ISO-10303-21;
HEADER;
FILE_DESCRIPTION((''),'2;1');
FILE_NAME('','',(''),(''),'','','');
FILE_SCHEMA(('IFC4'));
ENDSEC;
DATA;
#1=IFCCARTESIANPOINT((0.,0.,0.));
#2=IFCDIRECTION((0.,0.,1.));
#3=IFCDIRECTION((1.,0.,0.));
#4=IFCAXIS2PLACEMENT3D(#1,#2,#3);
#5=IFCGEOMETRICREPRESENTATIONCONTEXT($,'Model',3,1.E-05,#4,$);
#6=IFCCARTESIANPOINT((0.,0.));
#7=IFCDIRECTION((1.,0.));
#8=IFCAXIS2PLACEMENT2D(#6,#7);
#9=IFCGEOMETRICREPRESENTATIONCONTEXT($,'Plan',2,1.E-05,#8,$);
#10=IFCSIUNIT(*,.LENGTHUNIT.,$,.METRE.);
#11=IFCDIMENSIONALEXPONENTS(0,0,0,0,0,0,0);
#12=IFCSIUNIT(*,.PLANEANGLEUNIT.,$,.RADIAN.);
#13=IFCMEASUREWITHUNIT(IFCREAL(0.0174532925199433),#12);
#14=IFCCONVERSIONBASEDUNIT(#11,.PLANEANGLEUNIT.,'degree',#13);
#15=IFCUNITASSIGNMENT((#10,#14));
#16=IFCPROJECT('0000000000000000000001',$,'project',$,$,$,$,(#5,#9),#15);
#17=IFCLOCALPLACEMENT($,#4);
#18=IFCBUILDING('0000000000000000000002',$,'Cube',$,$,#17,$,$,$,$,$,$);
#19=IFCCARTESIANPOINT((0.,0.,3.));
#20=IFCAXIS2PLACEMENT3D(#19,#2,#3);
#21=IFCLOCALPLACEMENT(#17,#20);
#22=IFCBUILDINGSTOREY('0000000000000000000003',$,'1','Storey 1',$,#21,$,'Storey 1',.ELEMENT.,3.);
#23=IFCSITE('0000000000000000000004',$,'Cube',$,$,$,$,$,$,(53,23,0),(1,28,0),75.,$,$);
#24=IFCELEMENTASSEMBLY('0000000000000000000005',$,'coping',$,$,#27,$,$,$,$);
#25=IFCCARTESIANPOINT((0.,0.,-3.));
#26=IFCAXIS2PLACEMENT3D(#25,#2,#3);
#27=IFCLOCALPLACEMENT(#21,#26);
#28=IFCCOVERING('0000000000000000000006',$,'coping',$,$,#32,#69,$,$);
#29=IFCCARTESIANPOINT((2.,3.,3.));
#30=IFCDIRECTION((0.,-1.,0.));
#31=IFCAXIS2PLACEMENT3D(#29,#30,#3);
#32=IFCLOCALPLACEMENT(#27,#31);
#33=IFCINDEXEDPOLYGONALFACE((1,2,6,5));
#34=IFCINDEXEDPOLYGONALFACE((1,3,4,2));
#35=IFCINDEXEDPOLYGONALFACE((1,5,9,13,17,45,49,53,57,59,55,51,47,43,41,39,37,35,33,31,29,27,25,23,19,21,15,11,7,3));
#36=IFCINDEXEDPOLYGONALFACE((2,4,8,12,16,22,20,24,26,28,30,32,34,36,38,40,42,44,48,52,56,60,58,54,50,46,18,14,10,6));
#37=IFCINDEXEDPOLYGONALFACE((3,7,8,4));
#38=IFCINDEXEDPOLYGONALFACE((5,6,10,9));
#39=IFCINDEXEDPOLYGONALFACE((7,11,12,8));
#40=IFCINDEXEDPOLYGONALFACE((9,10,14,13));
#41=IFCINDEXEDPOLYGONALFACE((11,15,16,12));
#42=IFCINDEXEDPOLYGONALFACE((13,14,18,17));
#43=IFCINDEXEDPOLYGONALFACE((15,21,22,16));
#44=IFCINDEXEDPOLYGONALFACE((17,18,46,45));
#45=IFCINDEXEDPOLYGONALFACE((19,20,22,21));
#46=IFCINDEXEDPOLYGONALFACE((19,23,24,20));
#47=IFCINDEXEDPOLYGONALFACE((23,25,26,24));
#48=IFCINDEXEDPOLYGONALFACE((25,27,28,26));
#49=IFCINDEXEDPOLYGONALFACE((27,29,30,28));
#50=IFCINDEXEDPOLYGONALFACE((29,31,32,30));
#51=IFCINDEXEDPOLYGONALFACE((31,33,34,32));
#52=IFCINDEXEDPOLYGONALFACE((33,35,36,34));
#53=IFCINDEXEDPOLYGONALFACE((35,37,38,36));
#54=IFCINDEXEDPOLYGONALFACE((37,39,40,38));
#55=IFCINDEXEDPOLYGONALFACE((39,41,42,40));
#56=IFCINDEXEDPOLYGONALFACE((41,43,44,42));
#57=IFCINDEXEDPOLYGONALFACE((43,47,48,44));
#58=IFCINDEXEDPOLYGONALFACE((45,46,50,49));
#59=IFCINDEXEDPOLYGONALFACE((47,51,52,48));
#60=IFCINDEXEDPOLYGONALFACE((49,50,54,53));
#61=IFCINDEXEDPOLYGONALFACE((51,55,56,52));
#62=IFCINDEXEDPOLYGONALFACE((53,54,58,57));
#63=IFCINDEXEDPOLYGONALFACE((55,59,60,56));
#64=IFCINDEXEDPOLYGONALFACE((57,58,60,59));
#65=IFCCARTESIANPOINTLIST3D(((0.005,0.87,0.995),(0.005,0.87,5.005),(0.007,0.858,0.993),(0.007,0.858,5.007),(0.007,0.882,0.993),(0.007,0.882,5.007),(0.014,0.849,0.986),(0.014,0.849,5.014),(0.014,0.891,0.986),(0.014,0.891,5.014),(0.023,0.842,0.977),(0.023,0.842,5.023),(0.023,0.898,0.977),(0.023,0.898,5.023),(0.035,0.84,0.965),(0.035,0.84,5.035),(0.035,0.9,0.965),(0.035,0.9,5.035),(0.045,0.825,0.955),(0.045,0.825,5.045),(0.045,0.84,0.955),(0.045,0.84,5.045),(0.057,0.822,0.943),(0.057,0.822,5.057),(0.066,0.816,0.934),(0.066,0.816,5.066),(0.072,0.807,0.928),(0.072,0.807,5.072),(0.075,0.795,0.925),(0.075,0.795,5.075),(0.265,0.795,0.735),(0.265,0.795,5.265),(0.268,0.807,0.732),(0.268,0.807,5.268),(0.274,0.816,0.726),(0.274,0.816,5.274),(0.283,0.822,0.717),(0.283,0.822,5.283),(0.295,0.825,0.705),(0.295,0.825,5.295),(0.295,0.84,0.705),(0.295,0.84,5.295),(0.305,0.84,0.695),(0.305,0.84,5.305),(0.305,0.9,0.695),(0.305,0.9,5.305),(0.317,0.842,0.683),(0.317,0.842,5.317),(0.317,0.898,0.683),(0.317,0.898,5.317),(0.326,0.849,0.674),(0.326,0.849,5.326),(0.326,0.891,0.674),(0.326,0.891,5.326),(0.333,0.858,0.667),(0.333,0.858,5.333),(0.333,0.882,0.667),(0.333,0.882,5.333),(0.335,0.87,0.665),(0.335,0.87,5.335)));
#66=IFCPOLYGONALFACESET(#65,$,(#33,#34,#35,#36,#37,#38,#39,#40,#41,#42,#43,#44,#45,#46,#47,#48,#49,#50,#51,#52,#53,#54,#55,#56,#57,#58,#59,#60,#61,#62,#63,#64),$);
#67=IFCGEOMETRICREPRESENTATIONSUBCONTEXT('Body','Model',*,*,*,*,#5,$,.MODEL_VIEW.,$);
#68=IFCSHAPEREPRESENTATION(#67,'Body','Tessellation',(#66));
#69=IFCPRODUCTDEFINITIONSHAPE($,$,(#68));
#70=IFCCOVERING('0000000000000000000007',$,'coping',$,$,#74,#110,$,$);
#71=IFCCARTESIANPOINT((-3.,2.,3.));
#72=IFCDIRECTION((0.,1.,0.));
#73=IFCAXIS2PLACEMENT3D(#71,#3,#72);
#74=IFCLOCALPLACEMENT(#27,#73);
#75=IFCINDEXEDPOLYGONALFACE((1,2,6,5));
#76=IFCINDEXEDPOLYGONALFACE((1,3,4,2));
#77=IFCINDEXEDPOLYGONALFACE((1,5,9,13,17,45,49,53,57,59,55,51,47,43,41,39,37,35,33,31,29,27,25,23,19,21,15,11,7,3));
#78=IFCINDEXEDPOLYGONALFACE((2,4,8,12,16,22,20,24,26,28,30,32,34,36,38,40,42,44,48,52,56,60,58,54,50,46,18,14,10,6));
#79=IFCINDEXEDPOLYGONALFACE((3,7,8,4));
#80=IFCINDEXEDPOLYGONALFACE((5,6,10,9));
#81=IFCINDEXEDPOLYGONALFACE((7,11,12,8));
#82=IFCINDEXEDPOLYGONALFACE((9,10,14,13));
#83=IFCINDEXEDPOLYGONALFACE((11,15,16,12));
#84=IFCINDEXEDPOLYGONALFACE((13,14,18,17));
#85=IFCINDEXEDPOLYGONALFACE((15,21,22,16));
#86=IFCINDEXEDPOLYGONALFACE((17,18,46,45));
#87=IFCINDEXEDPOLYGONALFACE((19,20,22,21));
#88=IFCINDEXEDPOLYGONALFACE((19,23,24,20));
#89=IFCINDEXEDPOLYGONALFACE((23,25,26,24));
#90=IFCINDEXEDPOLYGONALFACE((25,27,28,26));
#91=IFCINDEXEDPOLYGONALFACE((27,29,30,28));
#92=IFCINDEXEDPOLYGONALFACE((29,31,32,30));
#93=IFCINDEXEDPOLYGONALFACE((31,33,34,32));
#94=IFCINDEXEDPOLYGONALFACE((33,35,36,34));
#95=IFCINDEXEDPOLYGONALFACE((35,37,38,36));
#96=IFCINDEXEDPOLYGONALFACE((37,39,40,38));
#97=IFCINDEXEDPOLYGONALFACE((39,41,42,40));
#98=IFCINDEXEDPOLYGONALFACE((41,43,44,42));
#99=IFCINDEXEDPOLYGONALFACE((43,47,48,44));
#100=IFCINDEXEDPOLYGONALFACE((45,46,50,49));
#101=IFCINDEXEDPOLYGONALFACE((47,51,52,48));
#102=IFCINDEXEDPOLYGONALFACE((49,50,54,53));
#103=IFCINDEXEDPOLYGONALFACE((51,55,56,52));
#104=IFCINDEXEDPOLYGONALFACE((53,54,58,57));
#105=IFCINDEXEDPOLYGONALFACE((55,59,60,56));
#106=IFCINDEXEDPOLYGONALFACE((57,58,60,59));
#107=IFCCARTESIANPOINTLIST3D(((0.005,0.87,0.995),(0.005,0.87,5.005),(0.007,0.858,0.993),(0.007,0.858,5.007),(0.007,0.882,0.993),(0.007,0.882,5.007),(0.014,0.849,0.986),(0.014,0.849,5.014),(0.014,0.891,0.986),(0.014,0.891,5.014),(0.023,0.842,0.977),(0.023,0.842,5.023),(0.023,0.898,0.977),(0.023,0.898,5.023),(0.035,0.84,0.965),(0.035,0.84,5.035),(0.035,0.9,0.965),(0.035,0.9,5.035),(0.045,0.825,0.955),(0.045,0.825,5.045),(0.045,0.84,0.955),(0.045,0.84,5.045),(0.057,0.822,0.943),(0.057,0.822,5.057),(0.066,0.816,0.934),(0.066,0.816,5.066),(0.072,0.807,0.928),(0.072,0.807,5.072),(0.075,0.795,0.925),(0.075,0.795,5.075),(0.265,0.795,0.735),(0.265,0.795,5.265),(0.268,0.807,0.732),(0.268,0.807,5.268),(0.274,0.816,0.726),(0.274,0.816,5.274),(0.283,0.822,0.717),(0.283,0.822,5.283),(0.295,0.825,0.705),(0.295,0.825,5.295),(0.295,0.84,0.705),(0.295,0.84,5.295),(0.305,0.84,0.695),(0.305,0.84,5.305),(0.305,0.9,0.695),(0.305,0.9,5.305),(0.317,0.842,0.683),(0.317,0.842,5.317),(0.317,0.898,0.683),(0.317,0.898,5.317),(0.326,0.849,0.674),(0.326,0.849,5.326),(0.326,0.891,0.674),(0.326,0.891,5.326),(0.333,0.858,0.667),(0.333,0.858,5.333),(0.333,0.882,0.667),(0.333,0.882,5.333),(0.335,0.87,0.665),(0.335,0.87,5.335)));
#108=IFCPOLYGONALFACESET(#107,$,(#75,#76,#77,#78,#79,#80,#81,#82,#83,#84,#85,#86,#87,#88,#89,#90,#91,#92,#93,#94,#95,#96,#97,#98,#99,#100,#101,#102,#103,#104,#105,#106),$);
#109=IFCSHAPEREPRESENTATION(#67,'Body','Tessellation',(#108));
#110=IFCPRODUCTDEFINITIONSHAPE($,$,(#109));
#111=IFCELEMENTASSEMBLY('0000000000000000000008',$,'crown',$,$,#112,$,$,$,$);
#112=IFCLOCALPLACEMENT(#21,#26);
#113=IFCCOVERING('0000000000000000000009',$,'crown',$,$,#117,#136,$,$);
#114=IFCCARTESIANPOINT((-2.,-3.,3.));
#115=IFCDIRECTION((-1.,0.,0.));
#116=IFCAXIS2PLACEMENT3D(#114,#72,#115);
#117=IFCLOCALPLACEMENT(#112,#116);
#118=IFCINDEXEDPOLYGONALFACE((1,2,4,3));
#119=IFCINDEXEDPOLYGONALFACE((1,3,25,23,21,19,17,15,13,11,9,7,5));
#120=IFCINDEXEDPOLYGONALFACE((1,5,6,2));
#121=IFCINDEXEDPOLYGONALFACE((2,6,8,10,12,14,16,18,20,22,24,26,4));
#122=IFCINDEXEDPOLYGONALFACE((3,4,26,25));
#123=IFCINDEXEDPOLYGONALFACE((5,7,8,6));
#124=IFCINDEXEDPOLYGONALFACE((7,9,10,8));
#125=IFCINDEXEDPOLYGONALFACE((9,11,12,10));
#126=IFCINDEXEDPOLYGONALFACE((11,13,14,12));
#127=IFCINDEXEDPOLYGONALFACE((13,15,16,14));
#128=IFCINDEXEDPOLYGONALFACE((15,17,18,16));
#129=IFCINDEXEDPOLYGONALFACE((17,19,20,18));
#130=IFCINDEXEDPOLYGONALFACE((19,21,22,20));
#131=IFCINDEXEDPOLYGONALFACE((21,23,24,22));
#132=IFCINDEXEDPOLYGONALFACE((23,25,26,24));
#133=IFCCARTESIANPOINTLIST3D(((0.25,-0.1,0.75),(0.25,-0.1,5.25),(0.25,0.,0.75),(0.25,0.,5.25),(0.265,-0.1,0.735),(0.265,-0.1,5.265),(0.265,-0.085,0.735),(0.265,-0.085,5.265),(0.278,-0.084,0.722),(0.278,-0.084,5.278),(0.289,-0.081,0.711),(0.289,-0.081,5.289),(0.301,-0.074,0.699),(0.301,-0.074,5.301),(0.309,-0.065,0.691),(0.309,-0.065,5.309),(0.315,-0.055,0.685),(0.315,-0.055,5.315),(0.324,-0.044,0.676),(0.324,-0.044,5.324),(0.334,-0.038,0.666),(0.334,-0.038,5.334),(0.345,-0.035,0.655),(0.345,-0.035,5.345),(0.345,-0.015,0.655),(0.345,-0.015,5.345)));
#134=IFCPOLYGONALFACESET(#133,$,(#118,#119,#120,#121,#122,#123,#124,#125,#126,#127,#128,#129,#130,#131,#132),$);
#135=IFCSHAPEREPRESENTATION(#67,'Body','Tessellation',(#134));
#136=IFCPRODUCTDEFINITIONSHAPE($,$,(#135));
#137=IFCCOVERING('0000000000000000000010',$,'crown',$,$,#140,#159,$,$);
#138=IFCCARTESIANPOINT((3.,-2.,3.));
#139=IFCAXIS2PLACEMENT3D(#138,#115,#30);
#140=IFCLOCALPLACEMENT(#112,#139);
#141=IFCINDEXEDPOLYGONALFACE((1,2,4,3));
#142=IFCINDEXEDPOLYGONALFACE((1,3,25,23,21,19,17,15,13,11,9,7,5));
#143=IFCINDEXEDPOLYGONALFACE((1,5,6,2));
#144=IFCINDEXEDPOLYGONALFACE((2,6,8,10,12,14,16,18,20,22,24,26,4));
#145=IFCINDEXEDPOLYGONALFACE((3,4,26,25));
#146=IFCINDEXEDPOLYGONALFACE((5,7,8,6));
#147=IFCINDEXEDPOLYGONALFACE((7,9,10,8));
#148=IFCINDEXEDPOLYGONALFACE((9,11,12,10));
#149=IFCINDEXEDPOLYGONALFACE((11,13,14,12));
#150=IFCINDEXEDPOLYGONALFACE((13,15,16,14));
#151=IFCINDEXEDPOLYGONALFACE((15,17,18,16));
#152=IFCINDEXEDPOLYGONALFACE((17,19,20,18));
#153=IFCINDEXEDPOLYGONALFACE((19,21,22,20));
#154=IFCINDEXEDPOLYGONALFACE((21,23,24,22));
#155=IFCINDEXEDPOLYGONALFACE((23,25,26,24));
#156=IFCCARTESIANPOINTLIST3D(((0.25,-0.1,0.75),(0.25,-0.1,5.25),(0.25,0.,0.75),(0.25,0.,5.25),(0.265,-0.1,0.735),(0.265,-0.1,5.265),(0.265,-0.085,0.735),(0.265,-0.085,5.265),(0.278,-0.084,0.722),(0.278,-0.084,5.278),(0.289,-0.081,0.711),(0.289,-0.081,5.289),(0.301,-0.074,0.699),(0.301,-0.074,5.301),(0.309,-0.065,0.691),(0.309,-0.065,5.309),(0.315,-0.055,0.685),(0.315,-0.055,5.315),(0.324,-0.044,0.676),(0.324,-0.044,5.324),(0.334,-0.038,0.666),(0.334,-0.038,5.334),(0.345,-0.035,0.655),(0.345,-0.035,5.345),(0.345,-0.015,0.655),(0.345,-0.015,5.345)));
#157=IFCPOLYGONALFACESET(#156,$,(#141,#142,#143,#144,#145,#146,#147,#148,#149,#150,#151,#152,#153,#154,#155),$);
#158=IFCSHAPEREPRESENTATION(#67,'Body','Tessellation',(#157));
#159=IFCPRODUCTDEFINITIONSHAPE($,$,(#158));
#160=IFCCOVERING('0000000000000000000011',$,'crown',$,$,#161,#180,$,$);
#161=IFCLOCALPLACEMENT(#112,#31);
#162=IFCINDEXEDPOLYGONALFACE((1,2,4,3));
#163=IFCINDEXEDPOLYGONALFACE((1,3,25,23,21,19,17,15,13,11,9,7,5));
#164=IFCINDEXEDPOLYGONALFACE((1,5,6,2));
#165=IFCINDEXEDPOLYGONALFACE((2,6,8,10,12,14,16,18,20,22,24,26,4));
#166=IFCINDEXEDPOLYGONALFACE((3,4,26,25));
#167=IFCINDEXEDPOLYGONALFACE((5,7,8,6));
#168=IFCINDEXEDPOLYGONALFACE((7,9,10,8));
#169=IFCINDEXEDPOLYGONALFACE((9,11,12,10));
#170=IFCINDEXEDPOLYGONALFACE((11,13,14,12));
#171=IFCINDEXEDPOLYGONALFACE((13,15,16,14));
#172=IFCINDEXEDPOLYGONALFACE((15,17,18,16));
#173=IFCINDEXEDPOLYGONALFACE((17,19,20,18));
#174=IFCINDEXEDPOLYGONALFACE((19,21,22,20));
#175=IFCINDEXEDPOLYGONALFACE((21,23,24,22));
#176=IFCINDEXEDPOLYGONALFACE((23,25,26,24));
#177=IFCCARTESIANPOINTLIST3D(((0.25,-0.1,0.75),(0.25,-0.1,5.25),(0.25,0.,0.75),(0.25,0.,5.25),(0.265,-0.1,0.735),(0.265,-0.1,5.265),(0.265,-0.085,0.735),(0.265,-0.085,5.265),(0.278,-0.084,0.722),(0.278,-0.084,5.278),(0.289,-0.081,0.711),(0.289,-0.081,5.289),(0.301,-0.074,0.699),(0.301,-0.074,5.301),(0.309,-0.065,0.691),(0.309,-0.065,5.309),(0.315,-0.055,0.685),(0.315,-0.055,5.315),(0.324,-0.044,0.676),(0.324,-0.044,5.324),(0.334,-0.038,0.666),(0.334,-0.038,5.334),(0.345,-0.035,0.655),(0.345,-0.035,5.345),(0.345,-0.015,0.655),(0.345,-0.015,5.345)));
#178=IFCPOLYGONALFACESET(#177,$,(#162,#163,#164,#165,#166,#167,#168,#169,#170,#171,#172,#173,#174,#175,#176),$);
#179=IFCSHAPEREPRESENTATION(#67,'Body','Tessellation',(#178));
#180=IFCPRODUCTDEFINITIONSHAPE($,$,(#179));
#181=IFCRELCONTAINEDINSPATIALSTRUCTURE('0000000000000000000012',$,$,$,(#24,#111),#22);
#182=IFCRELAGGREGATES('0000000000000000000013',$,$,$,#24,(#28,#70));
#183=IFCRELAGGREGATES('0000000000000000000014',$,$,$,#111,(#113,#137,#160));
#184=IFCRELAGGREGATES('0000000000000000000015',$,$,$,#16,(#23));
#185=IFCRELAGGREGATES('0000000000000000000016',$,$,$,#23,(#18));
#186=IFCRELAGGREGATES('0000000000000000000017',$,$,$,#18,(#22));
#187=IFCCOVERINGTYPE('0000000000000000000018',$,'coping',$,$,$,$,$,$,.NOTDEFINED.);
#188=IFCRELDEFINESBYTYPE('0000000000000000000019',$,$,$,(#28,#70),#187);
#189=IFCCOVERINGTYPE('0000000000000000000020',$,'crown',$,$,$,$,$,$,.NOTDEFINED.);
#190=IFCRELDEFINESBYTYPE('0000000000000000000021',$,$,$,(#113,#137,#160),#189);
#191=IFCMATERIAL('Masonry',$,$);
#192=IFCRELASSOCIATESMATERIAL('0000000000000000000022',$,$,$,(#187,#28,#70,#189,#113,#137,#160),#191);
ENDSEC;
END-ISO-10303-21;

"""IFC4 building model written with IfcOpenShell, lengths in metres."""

from ifc_helpers import new_model, entity, si_unit, converted_unit, frame, origin_with_axes, origin_2d_with_axis, place, context, subcontext, project, spatial, polyline, outline, extrude, clip, halfspace, material, material_profile, profile_set, profile_usage, type_object, element, aggregate, save


model = new_model("IFC4")

# Units and contexts
model_context = context("Model", 3, precision=1e-05, world=origin_with_axes())
plan_context = context("Plan", 2, precision=1e-05, world=origin_2d_with_axis())
body_context = subcontext(model_context, "Body", "Model", "MODEL_VIEW")
ifc_project = project(units=[si_unit("LENGTHUNIT", "METRE"), converted_unit("PLANEANGLEUNIT", "degree", entity("IfcReal", 0.0174532925199433), si_unit("PLANEANGLEUNIT", "RADIAN"), dimensions=[0, 0, 0, 0, 0, 0, 0])], contexts=[model_context, plan_context])

# Site, building, storey
site = spatial("IfcSite", under=ifc_project, Name="Cube", RefLatitude=(53, 23, 0), RefLongitude=(1, 28, 0), RefElevation=75.0)
building_placement = place(None, origin_with_axes())
building = spatial("IfcBuilding", under=site, at=building_placement, Name="Cube")
storey_placement = place(building_placement, frame((0.0, 0.0, 3.0), z_axis=(0.0, 0.0, 1.0), x_axis=(1.0, 0.0, 0.0)))
storey = spatial("IfcBuildingStorey", under=building, at=storey_placement, Name="1", Description="Storey 1", LongName="Storey 1", CompositionType="ELEMENT", Elevation=3.0)

# Shared definitions
ifc_material_1 = material(Name="Masonry")

# Element assemblies, coverings
assembly_1_placement = place(storey_placement, frame((0.0, 0.0, -3.0), z_axis=(0.0, 0.0, 1.0), x_axis=(1.0, 0.0, 0.0)))
assembly_1 = element("IfcElementAssembly", 1, at=assembly_1_placement, inside=storey, Name="coping")
ifc_material_profile_1 = material_profile(ifc_material_1, outline(polyline([(0.265, 0.795), (0.268, 0.807), (0.274, 0.816), (0.283, 0.822), (0.295, 0.825), (0.295, 0.84), (0.305, 0.84), (0.317, 0.842), (0.326, 0.849), (0.333, 0.858), (0.335, 0.87), (0.333, 0.882), (0.326, 0.891), (0.317, 0.898), (0.305, 0.9), (0.035, 0.9), (0.023, 0.898), (0.014, 0.891), (0.007, 0.882), (0.005, 0.87), (0.007, 0.858), (0.014, 0.849), (0.023, 0.842), (0.035, 0.84), (0.045, 0.84), (0.045, 0.825), (0.057, 0.822), (0.066, 0.816), (0.072, 0.807), (0.075, 0.795), (0.265, 0.795)])))
ifc_profile_set_1 = profile_set([ifc_material_profile_1])
covering_type_1 = type_object("IfcCoveringType", Name="coping", PredefinedType="NOTDEFINED", material=ifc_profile_set_1)
ifc_profile_usage_1 = profile_usage(ifc_profile_set_1)
covering_1_placement = place(assembly_1_placement, frame((2.0, 3.0, 3.0), z_axis=(0.0, -1.0, 0.0), x_axis=(1.0, 0.0, 0.0)))
covering_1 = element("IfcCovering", 2, at=covering_1_placement, type_object=covering_type_1, material=ifc_profile_usage_1, Name="coping", context=body_context, shape_type="Clipping", body=[
    clip(clip(extrude(outline(polyline([(0.265, 0.795), (0.268, 0.807), (0.274, 0.816), (0.283, 0.822), (0.295, 0.825), (0.295, 0.84), (0.305, 0.84), (0.317, 0.842), (0.326, 0.849), (0.333, 0.858), (0.335, 0.87), (0.333, 0.882), (0.326, 0.891), (0.317, 0.898), (0.305, 0.9), (0.035, 0.9), (0.023, 0.898), (0.014, 0.891), (0.007, 0.882), (0.005, 0.87), (0.007, 0.858), (0.014, 0.849), (0.023, 0.842), (0.035, 0.84), (0.045, 0.84), (0.045, 0.825), (0.057, 0.822), (0.066, 0.816), (0.072, 0.807), (0.075, 0.795), (0.265, 0.795)])), origin_with_axes(), (0.0, 0.0, 1.0), 6.0), halfspace(frame((0.0, -3.0, 1.0), z_axis=(-0.707107, 0.0, -0.707107), x_axis=(0.0, 1.0, 0.0)), False)), halfspace(frame((0.0, -3.0, 5.0), z_axis=(-0.707107, 0.0, 0.707107), x_axis=(0.0, 1.0, 0.0)), False)),
])
ifc_profile_usage_2 = profile_usage(ifc_profile_set_1)
covering_2_placement = place(assembly_1_placement, frame((-3.0, 2.0, 3.0), z_axis=(1.0, 0.0, 0.0), x_axis=(0.0, 1.0, 0.0)))
covering_2 = element("IfcCovering", 3, at=covering_2_placement, type_object=covering_type_1, material=ifc_profile_usage_2, Name="coping", context=body_context, shape_type="Clipping", body=[
    clip(clip(extrude(outline(polyline([(0.265, 0.795), (0.268, 0.807), (0.274, 0.816), (0.283, 0.822), (0.295, 0.825), (0.295, 0.84), (0.305, 0.84), (0.317, 0.842), (0.326, 0.849), (0.333, 0.858), (0.335, 0.87), (0.333, 0.882), (0.326, 0.891), (0.317, 0.898), (0.305, 0.9), (0.035, 0.9), (0.023, 0.898), (0.014, 0.891), (0.007, 0.882), (0.005, 0.87), (0.007, 0.858), (0.014, 0.849), (0.023, 0.842), (0.035, 0.84), (0.045, 0.84), (0.045, 0.825), (0.057, 0.822), (0.066, 0.816), (0.072, 0.807), (0.075, 0.795), (0.265, 0.795)])), origin_with_axes(), (0.0, 0.0, 1.0), 6.0), halfspace(frame((0.0, -3.0, 1.0), z_axis=(-0.707107, 0.0, -0.707107), x_axis=(0.0, 1.0, 0.0)), False)), halfspace(frame((0.0, -3.0, 5.0), z_axis=(-0.707107, 0.0, 0.707107), x_axis=(0.0, 1.0, 0.0)), False)),
])
aggregate(assembly_1, [covering_1, covering_2])
assembly_2_placement = place(storey_placement, frame((0.0, 0.0, -3.0), z_axis=(0.0, 0.0, 1.0), x_axis=(1.0, 0.0, 0.0)))
assembly_2 = element("IfcElementAssembly", 4, at=assembly_2_placement, inside=storey, Name="crown")
ifc_material_profile_2 = material_profile(ifc_material_1, outline(polyline([(0.25, -0.1), (0.265, -0.1), (0.265, -0.085), (0.278, -0.084), (0.289, -0.081), (0.301, -0.074), (0.309, -0.065), (0.315, -0.055), (0.324, -0.044), (0.334, -0.038), (0.345, -0.035), (0.345, -0.015), (0.25, 0.0), (0.25, -0.1)])))
ifc_profile_set_2 = profile_set([ifc_material_profile_2])
ifc_profile_usage_3 = profile_usage(ifc_profile_set_2)
covering_type_2 = type_object("IfcCoveringType", Name="crown", PredefinedType="NOTDEFINED", material=ifc_profile_set_2)
covering_3_placement = place(assembly_2_placement, frame((-2.0, -3.0, 3.0), z_axis=(0.0, 1.0, 0.0), x_axis=(-1.0, 0.0, 0.0)))
covering_3 = element("IfcCovering", 5, at=covering_3_placement, type_object=covering_type_2, material=ifc_profile_usage_3, Name="crown", context=body_context, shape_type="Clipping", body=[
    clip(clip(extrude(outline(polyline([(0.25, -0.1), (0.265, -0.1), (0.265, -0.085), (0.278, -0.084), (0.289, -0.081), (0.301, -0.074), (0.309, -0.065), (0.315, -0.055), (0.324, -0.044), (0.334, -0.038), (0.345, -0.035), (0.345, -0.015), (0.25, 0.0), (0.25, -0.1)])), origin_with_axes(), (0.0, 0.0, 1.0), 6.0), halfspace(frame((0.0, -3.0, 1.0), z_axis=(-0.707107, 0.0, -0.707107), x_axis=(0.0, 1.0, 0.0)), False)), halfspace(frame((0.0, -3.0, 5.0), z_axis=(-0.707107, 0.0, 0.707107), x_axis=(0.0, 1.0, 0.0)), False)),
])
ifc_profile_usage_4 = profile_usage(ifc_profile_set_2)
covering_4_placement = place(assembly_2_placement, frame((3.0, -2.0, 3.0), z_axis=(-1.0, 0.0, 0.0), x_axis=(0.0, -1.0, 0.0)))
covering_4 = element("IfcCovering", 6, at=covering_4_placement, type_object=covering_type_2, material=ifc_profile_usage_4, Name="crown", context=body_context, shape_type="Clipping", body=[
    clip(clip(extrude(outline(polyline([(0.25, -0.1), (0.265, -0.1), (0.265, -0.085), (0.278, -0.084), (0.289, -0.081), (0.301, -0.074), (0.309, -0.065), (0.315, -0.055), (0.324, -0.044), (0.334, -0.038), (0.345, -0.035), (0.345, -0.015), (0.25, 0.0), (0.25, -0.1)])), origin_with_axes(), (0.0, 0.0, 1.0), 6.0), halfspace(frame((0.0, -3.0, 1.0), z_axis=(-0.707107, 0.0, -0.707107), x_axis=(0.0, 1.0, 0.0)), False)), halfspace(frame((0.0, -3.0, 5.0), z_axis=(-0.707107, 0.0, 0.707107), x_axis=(0.0, 1.0, 0.0)), False)),
])
ifc_profile_usage_5 = profile_usage(ifc_profile_set_2)
covering_5_placement = place(assembly_2_placement, frame((2.0, 3.0, 3.0), z_axis=(0.0, -1.0, 0.0), x_axis=(1.0, 0.0, 0.0)))
covering_5 = element("IfcCovering", 7, at=covering_5_placement, type_object=covering_type_2, material=ifc_profile_usage_5, Name="crown", context=body_context, shape_type="Clipping", body=[
    clip(clip(extrude(outline(polyline([(0.25, -0.1), (0.265, -0.1), (0.265, -0.085), (0.278, -0.084), (0.289, -0.081), (0.301, -0.074), (0.309, -0.065), (0.315, -0.055), (0.324, -0.044), (0.334, -0.038), (0.345, -0.035), (0.345, -0.015), (0.25, 0.0), (0.25, -0.1)])), origin_with_axes(), (0.0, 0.0, 1.0), 6.0), halfspace(frame((0.0, -3.0, 1.0), z_axis=(-0.707107, 0.0, -0.707107), x_axis=(0.0, 1.0, 0.0)), False)), halfspace(frame((0.0, -3.0, 5.0), z_axis=(-0.707107, 0.0, 0.707107), x_axis=(0.0, 1.0, 0.0)), False)),
])
aggregate(assembly_2, [covering_3, covering_4, covering_5])

save(model, "model.ifc")
